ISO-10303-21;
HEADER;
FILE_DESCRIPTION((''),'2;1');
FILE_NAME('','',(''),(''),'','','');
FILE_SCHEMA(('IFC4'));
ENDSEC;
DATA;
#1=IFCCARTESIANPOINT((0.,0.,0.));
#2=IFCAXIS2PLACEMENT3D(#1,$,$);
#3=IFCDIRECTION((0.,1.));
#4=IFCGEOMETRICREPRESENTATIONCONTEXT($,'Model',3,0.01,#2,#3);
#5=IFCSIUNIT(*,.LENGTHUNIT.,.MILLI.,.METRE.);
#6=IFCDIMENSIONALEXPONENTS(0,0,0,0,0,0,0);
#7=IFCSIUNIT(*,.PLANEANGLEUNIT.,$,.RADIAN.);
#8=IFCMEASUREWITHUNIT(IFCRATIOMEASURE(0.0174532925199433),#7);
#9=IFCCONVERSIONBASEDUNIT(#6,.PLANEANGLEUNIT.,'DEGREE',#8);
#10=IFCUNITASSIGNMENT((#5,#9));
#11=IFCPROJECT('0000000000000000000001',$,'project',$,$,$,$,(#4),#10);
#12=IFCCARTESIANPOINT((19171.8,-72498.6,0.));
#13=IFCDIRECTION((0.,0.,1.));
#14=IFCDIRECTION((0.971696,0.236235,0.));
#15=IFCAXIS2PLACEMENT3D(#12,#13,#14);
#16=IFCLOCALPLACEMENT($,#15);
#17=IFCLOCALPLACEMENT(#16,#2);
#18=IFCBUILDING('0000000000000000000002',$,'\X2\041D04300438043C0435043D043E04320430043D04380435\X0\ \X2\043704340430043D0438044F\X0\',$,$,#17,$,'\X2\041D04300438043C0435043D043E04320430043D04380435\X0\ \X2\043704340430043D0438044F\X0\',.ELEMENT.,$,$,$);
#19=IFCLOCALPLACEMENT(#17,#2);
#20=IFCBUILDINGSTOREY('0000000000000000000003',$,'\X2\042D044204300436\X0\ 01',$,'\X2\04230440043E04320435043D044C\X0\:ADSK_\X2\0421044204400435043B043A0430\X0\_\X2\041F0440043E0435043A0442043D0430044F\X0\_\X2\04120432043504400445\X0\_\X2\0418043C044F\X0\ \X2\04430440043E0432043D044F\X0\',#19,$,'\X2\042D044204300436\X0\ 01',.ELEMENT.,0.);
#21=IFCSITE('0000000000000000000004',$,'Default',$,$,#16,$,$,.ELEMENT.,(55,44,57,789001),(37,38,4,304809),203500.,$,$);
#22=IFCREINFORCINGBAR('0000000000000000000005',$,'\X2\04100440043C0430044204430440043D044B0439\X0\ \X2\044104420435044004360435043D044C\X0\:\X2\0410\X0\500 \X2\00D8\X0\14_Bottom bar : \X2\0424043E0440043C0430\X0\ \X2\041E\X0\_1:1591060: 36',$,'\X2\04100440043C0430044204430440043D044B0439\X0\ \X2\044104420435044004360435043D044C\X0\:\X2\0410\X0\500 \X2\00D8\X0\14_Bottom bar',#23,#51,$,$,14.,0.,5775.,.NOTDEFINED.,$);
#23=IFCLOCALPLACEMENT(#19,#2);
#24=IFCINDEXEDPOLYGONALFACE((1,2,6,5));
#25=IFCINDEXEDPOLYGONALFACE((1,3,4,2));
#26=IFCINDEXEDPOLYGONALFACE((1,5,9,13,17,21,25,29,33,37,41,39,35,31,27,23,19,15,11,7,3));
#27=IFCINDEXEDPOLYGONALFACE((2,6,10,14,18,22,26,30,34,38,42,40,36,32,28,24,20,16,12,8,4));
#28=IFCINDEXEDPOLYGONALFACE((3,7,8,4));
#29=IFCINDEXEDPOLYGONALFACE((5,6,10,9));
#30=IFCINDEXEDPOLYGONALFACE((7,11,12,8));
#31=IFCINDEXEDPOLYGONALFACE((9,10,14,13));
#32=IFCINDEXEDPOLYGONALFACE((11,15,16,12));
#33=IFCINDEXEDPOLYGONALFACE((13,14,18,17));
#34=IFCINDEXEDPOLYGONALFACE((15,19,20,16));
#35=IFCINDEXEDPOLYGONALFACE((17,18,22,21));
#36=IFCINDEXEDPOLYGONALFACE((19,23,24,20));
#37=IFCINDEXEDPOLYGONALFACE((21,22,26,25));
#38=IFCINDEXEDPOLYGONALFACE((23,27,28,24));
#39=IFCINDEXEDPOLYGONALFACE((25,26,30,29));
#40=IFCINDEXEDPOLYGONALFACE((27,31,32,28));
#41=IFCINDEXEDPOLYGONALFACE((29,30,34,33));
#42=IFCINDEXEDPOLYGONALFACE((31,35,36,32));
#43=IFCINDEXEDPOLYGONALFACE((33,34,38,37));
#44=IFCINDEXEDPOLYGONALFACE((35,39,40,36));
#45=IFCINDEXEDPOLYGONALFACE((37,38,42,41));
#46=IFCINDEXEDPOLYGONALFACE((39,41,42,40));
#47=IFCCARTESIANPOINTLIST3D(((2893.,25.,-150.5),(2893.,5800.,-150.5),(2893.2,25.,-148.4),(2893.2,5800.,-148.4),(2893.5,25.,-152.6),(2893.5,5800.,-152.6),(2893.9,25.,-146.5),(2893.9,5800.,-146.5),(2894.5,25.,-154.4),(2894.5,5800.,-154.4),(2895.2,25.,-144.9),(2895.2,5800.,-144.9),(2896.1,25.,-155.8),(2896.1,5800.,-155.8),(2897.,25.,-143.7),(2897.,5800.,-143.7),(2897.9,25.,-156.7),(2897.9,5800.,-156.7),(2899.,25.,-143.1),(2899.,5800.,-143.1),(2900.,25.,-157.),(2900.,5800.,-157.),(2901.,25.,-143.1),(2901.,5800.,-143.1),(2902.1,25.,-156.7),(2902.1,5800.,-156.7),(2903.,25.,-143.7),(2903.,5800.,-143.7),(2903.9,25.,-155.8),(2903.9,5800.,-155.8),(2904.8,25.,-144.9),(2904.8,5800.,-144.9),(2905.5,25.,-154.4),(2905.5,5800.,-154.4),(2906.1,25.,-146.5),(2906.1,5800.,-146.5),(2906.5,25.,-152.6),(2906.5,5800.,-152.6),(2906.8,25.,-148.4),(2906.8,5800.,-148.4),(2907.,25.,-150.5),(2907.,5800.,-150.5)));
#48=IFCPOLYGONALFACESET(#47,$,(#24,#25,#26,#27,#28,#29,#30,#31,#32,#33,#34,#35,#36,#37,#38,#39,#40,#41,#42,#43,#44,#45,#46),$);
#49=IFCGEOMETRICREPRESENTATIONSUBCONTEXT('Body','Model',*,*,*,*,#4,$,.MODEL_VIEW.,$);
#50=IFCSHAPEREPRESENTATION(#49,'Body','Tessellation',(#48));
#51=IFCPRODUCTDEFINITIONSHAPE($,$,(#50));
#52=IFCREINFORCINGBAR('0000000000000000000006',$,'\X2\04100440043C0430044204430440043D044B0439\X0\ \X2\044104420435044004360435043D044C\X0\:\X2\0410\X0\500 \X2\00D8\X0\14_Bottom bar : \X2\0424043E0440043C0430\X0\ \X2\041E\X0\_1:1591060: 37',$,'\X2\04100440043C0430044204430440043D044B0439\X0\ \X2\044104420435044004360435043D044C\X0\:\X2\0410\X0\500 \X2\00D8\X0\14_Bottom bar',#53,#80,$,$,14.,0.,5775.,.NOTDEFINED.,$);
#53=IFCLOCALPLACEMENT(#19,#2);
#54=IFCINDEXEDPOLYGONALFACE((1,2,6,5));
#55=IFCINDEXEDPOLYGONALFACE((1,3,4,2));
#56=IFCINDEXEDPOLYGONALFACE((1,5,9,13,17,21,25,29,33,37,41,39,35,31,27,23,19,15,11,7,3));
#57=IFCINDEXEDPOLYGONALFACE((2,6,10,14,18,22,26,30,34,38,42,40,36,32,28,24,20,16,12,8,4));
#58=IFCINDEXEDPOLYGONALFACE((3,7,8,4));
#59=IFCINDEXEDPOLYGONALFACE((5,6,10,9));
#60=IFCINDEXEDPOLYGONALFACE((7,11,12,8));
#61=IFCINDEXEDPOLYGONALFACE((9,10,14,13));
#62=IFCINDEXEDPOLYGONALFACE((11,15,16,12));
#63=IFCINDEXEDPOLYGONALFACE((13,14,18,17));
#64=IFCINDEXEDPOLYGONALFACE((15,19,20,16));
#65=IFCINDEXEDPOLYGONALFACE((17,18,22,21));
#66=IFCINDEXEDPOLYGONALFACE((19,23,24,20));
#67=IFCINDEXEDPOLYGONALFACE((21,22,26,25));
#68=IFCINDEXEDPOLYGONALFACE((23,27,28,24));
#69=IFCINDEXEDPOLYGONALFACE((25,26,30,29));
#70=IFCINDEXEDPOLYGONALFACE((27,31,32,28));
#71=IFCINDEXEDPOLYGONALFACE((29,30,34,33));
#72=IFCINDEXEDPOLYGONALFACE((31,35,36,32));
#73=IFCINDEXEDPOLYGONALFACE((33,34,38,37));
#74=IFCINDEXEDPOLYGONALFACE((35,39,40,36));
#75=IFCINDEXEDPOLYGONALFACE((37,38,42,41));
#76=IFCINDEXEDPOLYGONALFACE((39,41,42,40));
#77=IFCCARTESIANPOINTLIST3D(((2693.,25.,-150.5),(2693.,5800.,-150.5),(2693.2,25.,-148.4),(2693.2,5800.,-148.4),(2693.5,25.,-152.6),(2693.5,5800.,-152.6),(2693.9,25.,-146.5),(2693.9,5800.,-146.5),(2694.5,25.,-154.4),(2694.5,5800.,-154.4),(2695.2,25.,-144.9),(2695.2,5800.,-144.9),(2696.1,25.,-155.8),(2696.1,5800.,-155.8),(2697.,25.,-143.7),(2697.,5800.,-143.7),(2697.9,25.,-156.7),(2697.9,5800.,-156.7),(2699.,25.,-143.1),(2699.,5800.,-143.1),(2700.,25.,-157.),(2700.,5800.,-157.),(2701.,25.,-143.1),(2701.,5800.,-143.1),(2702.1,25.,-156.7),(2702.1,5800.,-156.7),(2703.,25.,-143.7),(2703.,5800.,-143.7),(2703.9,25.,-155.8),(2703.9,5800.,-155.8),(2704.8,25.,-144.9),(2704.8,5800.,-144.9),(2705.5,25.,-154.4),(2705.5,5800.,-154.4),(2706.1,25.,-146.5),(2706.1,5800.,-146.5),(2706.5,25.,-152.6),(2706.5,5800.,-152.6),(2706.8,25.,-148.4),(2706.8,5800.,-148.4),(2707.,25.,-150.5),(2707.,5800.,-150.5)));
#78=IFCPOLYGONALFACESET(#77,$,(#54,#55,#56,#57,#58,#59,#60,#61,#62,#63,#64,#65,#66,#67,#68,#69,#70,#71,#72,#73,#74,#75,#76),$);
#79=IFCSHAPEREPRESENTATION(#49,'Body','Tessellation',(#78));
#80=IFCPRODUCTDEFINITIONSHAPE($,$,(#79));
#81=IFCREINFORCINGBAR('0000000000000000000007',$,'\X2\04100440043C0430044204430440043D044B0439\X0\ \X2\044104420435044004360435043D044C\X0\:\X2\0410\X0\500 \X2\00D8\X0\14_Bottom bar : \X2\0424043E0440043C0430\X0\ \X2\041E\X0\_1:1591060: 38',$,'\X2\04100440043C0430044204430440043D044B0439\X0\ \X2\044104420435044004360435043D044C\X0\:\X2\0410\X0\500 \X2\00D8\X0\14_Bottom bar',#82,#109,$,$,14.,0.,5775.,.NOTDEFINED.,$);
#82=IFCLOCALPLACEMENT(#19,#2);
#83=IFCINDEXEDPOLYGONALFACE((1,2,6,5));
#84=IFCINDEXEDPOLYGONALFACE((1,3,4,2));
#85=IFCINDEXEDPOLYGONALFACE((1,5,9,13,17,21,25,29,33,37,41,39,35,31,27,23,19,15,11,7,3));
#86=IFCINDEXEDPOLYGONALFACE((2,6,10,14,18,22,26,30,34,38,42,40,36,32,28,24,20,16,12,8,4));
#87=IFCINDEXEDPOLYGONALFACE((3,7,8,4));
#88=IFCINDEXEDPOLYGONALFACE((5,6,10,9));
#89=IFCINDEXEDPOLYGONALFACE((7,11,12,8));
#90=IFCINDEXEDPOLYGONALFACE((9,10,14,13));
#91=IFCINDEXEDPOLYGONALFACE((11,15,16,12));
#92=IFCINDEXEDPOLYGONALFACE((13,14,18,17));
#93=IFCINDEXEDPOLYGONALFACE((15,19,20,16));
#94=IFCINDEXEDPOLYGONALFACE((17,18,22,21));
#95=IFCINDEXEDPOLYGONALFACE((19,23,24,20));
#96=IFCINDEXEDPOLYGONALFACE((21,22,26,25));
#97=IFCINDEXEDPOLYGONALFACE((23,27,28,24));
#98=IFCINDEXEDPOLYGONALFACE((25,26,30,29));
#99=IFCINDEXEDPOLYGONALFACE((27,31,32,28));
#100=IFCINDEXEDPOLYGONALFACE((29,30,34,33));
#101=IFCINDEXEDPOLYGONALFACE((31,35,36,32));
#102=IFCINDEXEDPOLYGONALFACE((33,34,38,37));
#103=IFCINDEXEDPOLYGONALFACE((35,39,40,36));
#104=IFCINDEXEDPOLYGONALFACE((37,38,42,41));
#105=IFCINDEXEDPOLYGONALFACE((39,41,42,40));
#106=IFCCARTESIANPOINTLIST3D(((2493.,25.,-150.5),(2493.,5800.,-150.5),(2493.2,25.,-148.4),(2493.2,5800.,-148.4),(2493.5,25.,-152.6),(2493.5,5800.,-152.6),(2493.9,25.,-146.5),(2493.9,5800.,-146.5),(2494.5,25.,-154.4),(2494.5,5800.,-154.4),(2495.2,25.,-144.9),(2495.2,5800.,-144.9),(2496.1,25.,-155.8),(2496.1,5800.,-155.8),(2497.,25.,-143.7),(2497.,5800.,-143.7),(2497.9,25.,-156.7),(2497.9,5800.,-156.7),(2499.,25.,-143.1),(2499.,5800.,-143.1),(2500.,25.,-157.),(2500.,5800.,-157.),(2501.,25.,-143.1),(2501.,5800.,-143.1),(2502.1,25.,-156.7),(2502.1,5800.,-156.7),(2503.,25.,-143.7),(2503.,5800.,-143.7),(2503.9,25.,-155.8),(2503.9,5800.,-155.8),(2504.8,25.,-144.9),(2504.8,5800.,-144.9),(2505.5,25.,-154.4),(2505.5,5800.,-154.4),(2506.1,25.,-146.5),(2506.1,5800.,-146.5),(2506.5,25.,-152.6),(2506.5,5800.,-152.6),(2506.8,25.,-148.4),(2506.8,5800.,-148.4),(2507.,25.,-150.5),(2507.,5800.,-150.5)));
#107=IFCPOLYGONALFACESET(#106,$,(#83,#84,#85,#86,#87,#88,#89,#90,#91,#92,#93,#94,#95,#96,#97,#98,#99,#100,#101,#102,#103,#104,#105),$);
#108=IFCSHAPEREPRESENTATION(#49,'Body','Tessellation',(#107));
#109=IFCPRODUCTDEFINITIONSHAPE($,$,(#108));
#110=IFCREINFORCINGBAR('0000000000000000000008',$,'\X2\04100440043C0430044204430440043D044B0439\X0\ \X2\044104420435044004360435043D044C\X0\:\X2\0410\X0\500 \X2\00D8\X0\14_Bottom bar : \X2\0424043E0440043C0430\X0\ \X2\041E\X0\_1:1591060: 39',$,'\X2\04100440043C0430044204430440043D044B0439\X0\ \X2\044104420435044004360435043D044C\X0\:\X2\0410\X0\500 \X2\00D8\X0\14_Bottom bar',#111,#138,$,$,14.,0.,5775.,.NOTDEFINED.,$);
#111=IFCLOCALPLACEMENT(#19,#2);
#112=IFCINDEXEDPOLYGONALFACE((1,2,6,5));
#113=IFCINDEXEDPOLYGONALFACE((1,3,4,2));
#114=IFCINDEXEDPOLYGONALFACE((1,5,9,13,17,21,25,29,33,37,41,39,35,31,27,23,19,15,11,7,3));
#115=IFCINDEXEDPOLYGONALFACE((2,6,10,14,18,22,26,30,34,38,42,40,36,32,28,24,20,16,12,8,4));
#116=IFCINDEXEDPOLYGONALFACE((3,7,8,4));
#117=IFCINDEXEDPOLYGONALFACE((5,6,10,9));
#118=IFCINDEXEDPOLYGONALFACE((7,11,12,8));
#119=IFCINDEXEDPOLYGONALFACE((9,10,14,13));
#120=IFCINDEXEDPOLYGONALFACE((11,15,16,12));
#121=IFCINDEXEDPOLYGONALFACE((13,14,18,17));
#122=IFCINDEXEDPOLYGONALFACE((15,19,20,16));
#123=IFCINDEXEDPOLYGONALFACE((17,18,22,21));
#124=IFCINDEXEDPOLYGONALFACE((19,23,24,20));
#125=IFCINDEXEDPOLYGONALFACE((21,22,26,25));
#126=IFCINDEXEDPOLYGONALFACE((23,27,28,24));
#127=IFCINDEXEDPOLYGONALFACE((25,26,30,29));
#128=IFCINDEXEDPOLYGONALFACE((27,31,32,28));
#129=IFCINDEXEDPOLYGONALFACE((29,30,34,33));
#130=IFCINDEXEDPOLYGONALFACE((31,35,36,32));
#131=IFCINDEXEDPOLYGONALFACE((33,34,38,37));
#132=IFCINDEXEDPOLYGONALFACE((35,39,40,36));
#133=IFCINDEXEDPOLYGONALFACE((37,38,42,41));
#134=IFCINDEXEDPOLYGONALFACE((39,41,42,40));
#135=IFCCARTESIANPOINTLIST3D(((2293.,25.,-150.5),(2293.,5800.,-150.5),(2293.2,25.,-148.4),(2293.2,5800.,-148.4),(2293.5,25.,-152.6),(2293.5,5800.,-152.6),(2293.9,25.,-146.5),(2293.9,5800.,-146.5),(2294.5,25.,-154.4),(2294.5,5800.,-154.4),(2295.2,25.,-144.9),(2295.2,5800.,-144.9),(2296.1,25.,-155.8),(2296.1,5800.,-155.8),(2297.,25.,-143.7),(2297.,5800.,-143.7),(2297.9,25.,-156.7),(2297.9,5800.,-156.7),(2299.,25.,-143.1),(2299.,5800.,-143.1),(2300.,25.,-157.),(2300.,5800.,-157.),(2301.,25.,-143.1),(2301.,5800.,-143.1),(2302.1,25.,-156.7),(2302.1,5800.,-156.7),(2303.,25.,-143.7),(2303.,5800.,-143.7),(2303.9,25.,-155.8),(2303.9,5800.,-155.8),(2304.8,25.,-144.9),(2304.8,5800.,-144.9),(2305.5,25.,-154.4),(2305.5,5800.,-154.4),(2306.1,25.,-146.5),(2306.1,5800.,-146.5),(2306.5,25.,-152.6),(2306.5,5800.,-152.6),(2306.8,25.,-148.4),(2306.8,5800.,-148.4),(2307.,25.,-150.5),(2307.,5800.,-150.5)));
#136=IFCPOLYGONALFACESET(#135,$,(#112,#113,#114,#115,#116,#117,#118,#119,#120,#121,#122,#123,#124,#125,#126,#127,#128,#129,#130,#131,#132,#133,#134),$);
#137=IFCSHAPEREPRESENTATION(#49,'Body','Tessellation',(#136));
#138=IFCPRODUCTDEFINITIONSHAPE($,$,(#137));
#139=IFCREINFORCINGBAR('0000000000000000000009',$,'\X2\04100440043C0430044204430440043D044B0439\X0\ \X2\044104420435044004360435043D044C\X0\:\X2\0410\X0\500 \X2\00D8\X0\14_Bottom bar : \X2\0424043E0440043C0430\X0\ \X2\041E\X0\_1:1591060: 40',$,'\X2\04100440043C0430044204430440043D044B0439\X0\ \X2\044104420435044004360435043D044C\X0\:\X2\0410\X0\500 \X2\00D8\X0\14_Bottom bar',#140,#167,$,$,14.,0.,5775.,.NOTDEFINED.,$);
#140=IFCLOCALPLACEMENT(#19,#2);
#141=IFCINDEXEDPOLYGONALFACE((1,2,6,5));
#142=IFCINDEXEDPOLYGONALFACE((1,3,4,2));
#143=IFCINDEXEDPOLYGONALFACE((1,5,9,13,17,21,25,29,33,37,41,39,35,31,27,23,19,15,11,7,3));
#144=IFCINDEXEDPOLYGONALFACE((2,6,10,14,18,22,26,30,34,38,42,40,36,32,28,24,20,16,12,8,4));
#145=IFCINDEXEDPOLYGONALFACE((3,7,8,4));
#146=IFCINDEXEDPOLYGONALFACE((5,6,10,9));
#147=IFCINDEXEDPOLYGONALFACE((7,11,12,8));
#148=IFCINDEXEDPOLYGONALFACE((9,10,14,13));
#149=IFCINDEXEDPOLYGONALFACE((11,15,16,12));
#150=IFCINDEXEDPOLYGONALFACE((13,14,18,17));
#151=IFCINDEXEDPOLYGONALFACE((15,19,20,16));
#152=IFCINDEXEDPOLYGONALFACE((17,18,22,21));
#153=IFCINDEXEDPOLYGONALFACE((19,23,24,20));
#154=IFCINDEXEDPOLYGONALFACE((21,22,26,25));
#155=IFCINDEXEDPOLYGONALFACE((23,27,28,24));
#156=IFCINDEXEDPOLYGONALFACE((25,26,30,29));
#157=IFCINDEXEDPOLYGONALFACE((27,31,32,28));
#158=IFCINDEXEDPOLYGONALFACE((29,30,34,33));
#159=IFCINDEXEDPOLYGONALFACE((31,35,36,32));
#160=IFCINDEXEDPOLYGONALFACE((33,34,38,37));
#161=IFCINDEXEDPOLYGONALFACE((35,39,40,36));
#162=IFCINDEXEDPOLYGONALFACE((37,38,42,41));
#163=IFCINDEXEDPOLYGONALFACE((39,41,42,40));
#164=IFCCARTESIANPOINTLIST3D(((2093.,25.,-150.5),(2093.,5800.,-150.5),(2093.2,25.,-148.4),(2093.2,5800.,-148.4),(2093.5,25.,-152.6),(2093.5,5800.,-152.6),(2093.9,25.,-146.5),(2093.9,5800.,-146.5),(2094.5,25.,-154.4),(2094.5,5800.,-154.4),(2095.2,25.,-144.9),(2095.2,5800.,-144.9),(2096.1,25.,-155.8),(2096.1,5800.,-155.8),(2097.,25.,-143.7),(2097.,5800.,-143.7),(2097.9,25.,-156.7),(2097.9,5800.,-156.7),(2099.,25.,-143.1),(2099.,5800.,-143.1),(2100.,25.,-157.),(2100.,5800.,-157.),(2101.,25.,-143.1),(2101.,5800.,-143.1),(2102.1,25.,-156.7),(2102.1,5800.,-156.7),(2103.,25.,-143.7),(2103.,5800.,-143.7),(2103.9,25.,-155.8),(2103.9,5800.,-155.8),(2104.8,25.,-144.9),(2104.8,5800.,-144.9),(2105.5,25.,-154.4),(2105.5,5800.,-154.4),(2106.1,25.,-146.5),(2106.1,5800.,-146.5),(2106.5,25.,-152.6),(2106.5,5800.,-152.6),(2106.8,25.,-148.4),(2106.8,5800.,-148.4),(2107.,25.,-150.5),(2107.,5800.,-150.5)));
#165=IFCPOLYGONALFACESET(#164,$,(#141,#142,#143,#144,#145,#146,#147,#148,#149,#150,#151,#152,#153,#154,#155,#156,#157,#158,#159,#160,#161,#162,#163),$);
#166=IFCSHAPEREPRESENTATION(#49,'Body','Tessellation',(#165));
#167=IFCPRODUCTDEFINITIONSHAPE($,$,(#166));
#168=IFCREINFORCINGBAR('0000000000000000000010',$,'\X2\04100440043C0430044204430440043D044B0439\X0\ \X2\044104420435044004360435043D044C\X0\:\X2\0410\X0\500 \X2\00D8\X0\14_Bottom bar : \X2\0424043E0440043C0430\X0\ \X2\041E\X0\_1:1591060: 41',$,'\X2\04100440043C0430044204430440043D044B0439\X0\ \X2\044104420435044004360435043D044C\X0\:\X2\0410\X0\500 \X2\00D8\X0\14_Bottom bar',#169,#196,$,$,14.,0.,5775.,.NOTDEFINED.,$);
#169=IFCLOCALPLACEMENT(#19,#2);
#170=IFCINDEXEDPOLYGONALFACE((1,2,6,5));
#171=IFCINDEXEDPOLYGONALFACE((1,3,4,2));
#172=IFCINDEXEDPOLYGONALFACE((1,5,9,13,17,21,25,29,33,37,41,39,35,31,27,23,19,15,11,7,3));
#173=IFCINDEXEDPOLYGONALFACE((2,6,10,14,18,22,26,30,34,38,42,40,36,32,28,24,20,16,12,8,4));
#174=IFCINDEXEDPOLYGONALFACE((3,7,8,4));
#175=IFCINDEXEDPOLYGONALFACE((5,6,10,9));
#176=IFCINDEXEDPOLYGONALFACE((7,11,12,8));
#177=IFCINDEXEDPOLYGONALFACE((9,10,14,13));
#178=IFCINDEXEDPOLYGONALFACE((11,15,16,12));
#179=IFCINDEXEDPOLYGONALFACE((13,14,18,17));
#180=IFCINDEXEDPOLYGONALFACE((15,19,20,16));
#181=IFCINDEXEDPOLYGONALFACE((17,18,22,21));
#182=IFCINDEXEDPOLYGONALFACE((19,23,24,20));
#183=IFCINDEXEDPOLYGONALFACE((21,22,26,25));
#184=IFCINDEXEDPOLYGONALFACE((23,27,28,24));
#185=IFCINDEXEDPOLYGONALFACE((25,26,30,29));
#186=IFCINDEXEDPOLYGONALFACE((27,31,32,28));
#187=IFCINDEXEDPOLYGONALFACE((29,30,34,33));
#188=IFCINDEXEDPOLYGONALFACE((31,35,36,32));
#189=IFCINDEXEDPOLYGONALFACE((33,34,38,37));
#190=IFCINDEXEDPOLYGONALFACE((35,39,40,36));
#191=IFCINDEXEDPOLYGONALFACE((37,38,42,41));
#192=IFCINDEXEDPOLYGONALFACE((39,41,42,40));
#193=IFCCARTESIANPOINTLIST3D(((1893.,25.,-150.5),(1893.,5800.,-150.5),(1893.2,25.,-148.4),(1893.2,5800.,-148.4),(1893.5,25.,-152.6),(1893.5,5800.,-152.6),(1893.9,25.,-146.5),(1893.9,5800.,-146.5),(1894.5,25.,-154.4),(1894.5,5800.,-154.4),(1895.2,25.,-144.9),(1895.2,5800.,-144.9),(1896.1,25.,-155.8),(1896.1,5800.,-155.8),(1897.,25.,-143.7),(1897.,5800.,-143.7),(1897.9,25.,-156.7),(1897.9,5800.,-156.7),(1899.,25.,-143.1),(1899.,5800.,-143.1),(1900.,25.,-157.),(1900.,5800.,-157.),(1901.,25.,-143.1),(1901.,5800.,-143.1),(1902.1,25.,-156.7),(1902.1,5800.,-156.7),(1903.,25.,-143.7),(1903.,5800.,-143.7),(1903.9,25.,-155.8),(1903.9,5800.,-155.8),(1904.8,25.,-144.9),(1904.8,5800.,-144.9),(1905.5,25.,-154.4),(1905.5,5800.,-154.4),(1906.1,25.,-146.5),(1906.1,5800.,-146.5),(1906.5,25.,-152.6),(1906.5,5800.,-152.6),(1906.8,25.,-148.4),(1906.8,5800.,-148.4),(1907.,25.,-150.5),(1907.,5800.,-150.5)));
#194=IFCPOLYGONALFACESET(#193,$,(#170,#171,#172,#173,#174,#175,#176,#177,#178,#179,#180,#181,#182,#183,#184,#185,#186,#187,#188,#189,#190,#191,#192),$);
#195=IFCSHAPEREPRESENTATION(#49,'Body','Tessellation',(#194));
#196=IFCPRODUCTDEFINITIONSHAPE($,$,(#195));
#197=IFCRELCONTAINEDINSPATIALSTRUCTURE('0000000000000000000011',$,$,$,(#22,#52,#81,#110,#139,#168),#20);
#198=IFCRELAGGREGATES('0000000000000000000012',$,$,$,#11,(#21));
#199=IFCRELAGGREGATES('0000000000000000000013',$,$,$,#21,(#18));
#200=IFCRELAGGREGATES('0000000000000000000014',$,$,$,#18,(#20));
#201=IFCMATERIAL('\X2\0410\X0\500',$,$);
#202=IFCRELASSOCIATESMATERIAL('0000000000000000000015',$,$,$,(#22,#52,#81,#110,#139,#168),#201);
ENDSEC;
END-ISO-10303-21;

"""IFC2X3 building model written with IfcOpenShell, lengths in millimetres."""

from ifc_helpers import new_model, entity, si_unit, converted_unit, direction, frame, origin, place, context, subcontext, project, spatial, material, element, save


model = new_model("IFC2X3")

# Units and contexts
model_context = context("Model", 3, precision=0.01, world=origin(), true_north=direction((0.0, 1.0)))
body_context = subcontext(model_context, "Body", "Model", "MODEL_VIEW")
ifc_project = project(units=[si_unit("LENGTHUNIT", "METRE", prefix="MILLI"), converted_unit("PLANEANGLEUNIT", "DEGREE", entity("IfcRatioMeasure", 0.0174532925199433), si_unit("PLANEANGLEUNIT", "RADIAN"), dimensions=[0, 0, 0, 0, 0, 0, 0])], contexts=[model_context])

# Site, building, storey
site_placement = place(None, frame((19171.8, -72498.6, 0.0), z_axis=(0.0, 0.0, 1.0), x_axis=(0.971696, 0.236235, 0.0)))
site = spatial("IfcSite", under=ifc_project, at=site_placement, Name="Default", CompositionType="ELEMENT", RefLatitude=(55, 44, 57, 789001), RefLongitude=(37, 38, 4, 304809), RefElevation=203500.0)
building_placement = place(site_placement, origin())
building = spatial("IfcBuilding", under=site, at=building_placement, Name="Наименование здания", LongName="Наименование здания", CompositionType="ELEMENT")
storey_placement = place(building_placement, origin())
storey = spatial("IfcBuildingStorey", under=building, at=storey_placement, Name="Этаж 01", ObjectType="Уровень:ADSK_Стрелка_Проектная_Вверх_Имя уровня", LongName="Этаж 01", CompositionType="ELEMENT", Elevation=0.0)

# Reinforcing bars
ifc_material = material(Name="А500")
placement = place(storey_placement, origin())
element("IfcReinforcingBar", 1, at=placement, inside=storey, material=ifc_material, Name="Арматурный стержень:А500 Ø14_Bottom bar : Форма О_1:1591060: 36", ObjectType="Арматурный стержень:А500 Ø14_Bottom bar", BarLength=5775.0, BarRole="NOTDEFINED", CrossSectionArea=0.0, NominalDiameter=14.0, context=body_context, shape_type="AdvancedSweptSolid", body=[
    entity("IfcSweptDiskSolid", entity("IfcCompositeCurve", [entity("IfcCompositeCurveSegment", "CONTINUOUS", True, entity("IfcPolyline", [entity("IfcCartesianPoint", [2900.0, 5800.0, -150.0]), entity("IfcCartesianPoint", [2900.0, 25.0, -150.0])]))], False), 7.0, None, 0.0, 1.0),
])
element("IfcReinforcingBar", 2, at=placement, inside=storey, material=ifc_material, Name="Арматурный стержень:А500 Ø14_Bottom bar : Форма О_1:1591060: 37", ObjectType="Арматурный стержень:А500 Ø14_Bottom bar", BarLength=5775.0, BarRole="NOTDEFINED", CrossSectionArea=0.0, NominalDiameter=14.0, context=body_context, shape_type="AdvancedSweptSolid", body=[
    entity("IfcSweptDiskSolid", entity("IfcCompositeCurve", [entity("IfcCompositeCurveSegment", "CONTINUOUS", True, entity("IfcPolyline", [entity("IfcCartesianPoint", [2700.0, 5800.0, -150.0]), entity("IfcCartesianPoint", [2700.0, 25.0, -150.0])]))], False), 7.0, None, 0.0, 1.0),
])
element("IfcReinforcingBar", 3, at=placement, inside=storey, material=ifc_material, Name="Арматурный стержень:А500 Ø14_Bottom bar : Форма О_1:1591060: 38", ObjectType="Арматурный стержень:А500 Ø14_Bottom bar", BarLength=5775.0, BarRole="NOTDEFINED", CrossSectionArea=0.0, NominalDiameter=14.0, context=body_context, shape_type="AdvancedSweptSolid", body=[
    entity("IfcSweptDiskSolid", entity("IfcCompositeCurve", [entity("IfcCompositeCurveSegment", "CONTINUOUS", True, entity("IfcPolyline", [entity("IfcCartesianPoint", [2500.0, 5800.0, -150.0]), entity("IfcCartesianPoint", [2500.0, 25.0, -150.0])]))], False), 7.0, None, 0.0, 1.0),
])
element("IfcReinforcingBar", 4, at=placement, inside=storey, material=ifc_material, Name="Арматурный стержень:А500 Ø14_Bottom bar : Форма О_1:1591060: 39", ObjectType="Арматурный стержень:А500 Ø14_Bottom bar", BarLength=5775.0, BarRole="NOTDEFINED", CrossSectionArea=0.0, NominalDiameter=14.0, context=body_context, shape_type="AdvancedSweptSolid", body=[
    entity("IfcSweptDiskSolid", entity("IfcCompositeCurve", [entity("IfcCompositeCurveSegment", "CONTINUOUS", True, entity("IfcPolyline", [entity("IfcCartesianPoint", [2300.0, 5800.0, -150.0]), entity("IfcCartesianPoint", [2300.0, 25.0, -150.0])]))], False), 7.0, None, 0.0, 1.0),
])
element("IfcReinforcingBar", 5, at=placement, inside=storey, material=ifc_material, Name="Арматурный стержень:А500 Ø14_Bottom bar : Форма О_1:1591060: 40", ObjectType="Арматурный стержень:А500 Ø14_Bottom bar", BarLength=5775.0, BarRole="NOTDEFINED", CrossSectionArea=0.0, NominalDiameter=14.0, context=body_context, shape_type="AdvancedSweptSolid", body=[
    entity("IfcSweptDiskSolid", entity("IfcCompositeCurve", [entity("IfcCompositeCurveSegment", "CONTINUOUS", True, entity("IfcPolyline", [entity("IfcCartesianPoint", [2100.0, 5800.0, -150.0]), entity("IfcCartesianPoint", [2100.0, 25.0, -150.0])]))], False), 7.0, None, 0.0, 1.0),
])
element("IfcReinforcingBar", 6, at=placement, inside=storey, material=ifc_material, Name="Арматурный стержень:А500 Ø14_Bottom bar : Форма О_1:1591060: 41", ObjectType="Арматурный стержень:А500 Ø14_Bottom bar", BarLength=5775.0, BarRole="NOTDEFINED", CrossSectionArea=0.0, NominalDiameter=14.0, context=body_context, shape_type="AdvancedSweptSolid", body=[
    entity("IfcSweptDiskSolid", entity("IfcCompositeCurve", [entity("IfcCompositeCurveSegment", "CONTINUOUS", True, entity("IfcPolyline", [entity("IfcCartesianPoint", [1900.0, 5800.0, -150.0]), entity("IfcCartesianPoint", [1900.0, 25.0, -150.0])]))], False), 7.0, None, 0.0, 1.0),
])

save(model, "model.ifc")
